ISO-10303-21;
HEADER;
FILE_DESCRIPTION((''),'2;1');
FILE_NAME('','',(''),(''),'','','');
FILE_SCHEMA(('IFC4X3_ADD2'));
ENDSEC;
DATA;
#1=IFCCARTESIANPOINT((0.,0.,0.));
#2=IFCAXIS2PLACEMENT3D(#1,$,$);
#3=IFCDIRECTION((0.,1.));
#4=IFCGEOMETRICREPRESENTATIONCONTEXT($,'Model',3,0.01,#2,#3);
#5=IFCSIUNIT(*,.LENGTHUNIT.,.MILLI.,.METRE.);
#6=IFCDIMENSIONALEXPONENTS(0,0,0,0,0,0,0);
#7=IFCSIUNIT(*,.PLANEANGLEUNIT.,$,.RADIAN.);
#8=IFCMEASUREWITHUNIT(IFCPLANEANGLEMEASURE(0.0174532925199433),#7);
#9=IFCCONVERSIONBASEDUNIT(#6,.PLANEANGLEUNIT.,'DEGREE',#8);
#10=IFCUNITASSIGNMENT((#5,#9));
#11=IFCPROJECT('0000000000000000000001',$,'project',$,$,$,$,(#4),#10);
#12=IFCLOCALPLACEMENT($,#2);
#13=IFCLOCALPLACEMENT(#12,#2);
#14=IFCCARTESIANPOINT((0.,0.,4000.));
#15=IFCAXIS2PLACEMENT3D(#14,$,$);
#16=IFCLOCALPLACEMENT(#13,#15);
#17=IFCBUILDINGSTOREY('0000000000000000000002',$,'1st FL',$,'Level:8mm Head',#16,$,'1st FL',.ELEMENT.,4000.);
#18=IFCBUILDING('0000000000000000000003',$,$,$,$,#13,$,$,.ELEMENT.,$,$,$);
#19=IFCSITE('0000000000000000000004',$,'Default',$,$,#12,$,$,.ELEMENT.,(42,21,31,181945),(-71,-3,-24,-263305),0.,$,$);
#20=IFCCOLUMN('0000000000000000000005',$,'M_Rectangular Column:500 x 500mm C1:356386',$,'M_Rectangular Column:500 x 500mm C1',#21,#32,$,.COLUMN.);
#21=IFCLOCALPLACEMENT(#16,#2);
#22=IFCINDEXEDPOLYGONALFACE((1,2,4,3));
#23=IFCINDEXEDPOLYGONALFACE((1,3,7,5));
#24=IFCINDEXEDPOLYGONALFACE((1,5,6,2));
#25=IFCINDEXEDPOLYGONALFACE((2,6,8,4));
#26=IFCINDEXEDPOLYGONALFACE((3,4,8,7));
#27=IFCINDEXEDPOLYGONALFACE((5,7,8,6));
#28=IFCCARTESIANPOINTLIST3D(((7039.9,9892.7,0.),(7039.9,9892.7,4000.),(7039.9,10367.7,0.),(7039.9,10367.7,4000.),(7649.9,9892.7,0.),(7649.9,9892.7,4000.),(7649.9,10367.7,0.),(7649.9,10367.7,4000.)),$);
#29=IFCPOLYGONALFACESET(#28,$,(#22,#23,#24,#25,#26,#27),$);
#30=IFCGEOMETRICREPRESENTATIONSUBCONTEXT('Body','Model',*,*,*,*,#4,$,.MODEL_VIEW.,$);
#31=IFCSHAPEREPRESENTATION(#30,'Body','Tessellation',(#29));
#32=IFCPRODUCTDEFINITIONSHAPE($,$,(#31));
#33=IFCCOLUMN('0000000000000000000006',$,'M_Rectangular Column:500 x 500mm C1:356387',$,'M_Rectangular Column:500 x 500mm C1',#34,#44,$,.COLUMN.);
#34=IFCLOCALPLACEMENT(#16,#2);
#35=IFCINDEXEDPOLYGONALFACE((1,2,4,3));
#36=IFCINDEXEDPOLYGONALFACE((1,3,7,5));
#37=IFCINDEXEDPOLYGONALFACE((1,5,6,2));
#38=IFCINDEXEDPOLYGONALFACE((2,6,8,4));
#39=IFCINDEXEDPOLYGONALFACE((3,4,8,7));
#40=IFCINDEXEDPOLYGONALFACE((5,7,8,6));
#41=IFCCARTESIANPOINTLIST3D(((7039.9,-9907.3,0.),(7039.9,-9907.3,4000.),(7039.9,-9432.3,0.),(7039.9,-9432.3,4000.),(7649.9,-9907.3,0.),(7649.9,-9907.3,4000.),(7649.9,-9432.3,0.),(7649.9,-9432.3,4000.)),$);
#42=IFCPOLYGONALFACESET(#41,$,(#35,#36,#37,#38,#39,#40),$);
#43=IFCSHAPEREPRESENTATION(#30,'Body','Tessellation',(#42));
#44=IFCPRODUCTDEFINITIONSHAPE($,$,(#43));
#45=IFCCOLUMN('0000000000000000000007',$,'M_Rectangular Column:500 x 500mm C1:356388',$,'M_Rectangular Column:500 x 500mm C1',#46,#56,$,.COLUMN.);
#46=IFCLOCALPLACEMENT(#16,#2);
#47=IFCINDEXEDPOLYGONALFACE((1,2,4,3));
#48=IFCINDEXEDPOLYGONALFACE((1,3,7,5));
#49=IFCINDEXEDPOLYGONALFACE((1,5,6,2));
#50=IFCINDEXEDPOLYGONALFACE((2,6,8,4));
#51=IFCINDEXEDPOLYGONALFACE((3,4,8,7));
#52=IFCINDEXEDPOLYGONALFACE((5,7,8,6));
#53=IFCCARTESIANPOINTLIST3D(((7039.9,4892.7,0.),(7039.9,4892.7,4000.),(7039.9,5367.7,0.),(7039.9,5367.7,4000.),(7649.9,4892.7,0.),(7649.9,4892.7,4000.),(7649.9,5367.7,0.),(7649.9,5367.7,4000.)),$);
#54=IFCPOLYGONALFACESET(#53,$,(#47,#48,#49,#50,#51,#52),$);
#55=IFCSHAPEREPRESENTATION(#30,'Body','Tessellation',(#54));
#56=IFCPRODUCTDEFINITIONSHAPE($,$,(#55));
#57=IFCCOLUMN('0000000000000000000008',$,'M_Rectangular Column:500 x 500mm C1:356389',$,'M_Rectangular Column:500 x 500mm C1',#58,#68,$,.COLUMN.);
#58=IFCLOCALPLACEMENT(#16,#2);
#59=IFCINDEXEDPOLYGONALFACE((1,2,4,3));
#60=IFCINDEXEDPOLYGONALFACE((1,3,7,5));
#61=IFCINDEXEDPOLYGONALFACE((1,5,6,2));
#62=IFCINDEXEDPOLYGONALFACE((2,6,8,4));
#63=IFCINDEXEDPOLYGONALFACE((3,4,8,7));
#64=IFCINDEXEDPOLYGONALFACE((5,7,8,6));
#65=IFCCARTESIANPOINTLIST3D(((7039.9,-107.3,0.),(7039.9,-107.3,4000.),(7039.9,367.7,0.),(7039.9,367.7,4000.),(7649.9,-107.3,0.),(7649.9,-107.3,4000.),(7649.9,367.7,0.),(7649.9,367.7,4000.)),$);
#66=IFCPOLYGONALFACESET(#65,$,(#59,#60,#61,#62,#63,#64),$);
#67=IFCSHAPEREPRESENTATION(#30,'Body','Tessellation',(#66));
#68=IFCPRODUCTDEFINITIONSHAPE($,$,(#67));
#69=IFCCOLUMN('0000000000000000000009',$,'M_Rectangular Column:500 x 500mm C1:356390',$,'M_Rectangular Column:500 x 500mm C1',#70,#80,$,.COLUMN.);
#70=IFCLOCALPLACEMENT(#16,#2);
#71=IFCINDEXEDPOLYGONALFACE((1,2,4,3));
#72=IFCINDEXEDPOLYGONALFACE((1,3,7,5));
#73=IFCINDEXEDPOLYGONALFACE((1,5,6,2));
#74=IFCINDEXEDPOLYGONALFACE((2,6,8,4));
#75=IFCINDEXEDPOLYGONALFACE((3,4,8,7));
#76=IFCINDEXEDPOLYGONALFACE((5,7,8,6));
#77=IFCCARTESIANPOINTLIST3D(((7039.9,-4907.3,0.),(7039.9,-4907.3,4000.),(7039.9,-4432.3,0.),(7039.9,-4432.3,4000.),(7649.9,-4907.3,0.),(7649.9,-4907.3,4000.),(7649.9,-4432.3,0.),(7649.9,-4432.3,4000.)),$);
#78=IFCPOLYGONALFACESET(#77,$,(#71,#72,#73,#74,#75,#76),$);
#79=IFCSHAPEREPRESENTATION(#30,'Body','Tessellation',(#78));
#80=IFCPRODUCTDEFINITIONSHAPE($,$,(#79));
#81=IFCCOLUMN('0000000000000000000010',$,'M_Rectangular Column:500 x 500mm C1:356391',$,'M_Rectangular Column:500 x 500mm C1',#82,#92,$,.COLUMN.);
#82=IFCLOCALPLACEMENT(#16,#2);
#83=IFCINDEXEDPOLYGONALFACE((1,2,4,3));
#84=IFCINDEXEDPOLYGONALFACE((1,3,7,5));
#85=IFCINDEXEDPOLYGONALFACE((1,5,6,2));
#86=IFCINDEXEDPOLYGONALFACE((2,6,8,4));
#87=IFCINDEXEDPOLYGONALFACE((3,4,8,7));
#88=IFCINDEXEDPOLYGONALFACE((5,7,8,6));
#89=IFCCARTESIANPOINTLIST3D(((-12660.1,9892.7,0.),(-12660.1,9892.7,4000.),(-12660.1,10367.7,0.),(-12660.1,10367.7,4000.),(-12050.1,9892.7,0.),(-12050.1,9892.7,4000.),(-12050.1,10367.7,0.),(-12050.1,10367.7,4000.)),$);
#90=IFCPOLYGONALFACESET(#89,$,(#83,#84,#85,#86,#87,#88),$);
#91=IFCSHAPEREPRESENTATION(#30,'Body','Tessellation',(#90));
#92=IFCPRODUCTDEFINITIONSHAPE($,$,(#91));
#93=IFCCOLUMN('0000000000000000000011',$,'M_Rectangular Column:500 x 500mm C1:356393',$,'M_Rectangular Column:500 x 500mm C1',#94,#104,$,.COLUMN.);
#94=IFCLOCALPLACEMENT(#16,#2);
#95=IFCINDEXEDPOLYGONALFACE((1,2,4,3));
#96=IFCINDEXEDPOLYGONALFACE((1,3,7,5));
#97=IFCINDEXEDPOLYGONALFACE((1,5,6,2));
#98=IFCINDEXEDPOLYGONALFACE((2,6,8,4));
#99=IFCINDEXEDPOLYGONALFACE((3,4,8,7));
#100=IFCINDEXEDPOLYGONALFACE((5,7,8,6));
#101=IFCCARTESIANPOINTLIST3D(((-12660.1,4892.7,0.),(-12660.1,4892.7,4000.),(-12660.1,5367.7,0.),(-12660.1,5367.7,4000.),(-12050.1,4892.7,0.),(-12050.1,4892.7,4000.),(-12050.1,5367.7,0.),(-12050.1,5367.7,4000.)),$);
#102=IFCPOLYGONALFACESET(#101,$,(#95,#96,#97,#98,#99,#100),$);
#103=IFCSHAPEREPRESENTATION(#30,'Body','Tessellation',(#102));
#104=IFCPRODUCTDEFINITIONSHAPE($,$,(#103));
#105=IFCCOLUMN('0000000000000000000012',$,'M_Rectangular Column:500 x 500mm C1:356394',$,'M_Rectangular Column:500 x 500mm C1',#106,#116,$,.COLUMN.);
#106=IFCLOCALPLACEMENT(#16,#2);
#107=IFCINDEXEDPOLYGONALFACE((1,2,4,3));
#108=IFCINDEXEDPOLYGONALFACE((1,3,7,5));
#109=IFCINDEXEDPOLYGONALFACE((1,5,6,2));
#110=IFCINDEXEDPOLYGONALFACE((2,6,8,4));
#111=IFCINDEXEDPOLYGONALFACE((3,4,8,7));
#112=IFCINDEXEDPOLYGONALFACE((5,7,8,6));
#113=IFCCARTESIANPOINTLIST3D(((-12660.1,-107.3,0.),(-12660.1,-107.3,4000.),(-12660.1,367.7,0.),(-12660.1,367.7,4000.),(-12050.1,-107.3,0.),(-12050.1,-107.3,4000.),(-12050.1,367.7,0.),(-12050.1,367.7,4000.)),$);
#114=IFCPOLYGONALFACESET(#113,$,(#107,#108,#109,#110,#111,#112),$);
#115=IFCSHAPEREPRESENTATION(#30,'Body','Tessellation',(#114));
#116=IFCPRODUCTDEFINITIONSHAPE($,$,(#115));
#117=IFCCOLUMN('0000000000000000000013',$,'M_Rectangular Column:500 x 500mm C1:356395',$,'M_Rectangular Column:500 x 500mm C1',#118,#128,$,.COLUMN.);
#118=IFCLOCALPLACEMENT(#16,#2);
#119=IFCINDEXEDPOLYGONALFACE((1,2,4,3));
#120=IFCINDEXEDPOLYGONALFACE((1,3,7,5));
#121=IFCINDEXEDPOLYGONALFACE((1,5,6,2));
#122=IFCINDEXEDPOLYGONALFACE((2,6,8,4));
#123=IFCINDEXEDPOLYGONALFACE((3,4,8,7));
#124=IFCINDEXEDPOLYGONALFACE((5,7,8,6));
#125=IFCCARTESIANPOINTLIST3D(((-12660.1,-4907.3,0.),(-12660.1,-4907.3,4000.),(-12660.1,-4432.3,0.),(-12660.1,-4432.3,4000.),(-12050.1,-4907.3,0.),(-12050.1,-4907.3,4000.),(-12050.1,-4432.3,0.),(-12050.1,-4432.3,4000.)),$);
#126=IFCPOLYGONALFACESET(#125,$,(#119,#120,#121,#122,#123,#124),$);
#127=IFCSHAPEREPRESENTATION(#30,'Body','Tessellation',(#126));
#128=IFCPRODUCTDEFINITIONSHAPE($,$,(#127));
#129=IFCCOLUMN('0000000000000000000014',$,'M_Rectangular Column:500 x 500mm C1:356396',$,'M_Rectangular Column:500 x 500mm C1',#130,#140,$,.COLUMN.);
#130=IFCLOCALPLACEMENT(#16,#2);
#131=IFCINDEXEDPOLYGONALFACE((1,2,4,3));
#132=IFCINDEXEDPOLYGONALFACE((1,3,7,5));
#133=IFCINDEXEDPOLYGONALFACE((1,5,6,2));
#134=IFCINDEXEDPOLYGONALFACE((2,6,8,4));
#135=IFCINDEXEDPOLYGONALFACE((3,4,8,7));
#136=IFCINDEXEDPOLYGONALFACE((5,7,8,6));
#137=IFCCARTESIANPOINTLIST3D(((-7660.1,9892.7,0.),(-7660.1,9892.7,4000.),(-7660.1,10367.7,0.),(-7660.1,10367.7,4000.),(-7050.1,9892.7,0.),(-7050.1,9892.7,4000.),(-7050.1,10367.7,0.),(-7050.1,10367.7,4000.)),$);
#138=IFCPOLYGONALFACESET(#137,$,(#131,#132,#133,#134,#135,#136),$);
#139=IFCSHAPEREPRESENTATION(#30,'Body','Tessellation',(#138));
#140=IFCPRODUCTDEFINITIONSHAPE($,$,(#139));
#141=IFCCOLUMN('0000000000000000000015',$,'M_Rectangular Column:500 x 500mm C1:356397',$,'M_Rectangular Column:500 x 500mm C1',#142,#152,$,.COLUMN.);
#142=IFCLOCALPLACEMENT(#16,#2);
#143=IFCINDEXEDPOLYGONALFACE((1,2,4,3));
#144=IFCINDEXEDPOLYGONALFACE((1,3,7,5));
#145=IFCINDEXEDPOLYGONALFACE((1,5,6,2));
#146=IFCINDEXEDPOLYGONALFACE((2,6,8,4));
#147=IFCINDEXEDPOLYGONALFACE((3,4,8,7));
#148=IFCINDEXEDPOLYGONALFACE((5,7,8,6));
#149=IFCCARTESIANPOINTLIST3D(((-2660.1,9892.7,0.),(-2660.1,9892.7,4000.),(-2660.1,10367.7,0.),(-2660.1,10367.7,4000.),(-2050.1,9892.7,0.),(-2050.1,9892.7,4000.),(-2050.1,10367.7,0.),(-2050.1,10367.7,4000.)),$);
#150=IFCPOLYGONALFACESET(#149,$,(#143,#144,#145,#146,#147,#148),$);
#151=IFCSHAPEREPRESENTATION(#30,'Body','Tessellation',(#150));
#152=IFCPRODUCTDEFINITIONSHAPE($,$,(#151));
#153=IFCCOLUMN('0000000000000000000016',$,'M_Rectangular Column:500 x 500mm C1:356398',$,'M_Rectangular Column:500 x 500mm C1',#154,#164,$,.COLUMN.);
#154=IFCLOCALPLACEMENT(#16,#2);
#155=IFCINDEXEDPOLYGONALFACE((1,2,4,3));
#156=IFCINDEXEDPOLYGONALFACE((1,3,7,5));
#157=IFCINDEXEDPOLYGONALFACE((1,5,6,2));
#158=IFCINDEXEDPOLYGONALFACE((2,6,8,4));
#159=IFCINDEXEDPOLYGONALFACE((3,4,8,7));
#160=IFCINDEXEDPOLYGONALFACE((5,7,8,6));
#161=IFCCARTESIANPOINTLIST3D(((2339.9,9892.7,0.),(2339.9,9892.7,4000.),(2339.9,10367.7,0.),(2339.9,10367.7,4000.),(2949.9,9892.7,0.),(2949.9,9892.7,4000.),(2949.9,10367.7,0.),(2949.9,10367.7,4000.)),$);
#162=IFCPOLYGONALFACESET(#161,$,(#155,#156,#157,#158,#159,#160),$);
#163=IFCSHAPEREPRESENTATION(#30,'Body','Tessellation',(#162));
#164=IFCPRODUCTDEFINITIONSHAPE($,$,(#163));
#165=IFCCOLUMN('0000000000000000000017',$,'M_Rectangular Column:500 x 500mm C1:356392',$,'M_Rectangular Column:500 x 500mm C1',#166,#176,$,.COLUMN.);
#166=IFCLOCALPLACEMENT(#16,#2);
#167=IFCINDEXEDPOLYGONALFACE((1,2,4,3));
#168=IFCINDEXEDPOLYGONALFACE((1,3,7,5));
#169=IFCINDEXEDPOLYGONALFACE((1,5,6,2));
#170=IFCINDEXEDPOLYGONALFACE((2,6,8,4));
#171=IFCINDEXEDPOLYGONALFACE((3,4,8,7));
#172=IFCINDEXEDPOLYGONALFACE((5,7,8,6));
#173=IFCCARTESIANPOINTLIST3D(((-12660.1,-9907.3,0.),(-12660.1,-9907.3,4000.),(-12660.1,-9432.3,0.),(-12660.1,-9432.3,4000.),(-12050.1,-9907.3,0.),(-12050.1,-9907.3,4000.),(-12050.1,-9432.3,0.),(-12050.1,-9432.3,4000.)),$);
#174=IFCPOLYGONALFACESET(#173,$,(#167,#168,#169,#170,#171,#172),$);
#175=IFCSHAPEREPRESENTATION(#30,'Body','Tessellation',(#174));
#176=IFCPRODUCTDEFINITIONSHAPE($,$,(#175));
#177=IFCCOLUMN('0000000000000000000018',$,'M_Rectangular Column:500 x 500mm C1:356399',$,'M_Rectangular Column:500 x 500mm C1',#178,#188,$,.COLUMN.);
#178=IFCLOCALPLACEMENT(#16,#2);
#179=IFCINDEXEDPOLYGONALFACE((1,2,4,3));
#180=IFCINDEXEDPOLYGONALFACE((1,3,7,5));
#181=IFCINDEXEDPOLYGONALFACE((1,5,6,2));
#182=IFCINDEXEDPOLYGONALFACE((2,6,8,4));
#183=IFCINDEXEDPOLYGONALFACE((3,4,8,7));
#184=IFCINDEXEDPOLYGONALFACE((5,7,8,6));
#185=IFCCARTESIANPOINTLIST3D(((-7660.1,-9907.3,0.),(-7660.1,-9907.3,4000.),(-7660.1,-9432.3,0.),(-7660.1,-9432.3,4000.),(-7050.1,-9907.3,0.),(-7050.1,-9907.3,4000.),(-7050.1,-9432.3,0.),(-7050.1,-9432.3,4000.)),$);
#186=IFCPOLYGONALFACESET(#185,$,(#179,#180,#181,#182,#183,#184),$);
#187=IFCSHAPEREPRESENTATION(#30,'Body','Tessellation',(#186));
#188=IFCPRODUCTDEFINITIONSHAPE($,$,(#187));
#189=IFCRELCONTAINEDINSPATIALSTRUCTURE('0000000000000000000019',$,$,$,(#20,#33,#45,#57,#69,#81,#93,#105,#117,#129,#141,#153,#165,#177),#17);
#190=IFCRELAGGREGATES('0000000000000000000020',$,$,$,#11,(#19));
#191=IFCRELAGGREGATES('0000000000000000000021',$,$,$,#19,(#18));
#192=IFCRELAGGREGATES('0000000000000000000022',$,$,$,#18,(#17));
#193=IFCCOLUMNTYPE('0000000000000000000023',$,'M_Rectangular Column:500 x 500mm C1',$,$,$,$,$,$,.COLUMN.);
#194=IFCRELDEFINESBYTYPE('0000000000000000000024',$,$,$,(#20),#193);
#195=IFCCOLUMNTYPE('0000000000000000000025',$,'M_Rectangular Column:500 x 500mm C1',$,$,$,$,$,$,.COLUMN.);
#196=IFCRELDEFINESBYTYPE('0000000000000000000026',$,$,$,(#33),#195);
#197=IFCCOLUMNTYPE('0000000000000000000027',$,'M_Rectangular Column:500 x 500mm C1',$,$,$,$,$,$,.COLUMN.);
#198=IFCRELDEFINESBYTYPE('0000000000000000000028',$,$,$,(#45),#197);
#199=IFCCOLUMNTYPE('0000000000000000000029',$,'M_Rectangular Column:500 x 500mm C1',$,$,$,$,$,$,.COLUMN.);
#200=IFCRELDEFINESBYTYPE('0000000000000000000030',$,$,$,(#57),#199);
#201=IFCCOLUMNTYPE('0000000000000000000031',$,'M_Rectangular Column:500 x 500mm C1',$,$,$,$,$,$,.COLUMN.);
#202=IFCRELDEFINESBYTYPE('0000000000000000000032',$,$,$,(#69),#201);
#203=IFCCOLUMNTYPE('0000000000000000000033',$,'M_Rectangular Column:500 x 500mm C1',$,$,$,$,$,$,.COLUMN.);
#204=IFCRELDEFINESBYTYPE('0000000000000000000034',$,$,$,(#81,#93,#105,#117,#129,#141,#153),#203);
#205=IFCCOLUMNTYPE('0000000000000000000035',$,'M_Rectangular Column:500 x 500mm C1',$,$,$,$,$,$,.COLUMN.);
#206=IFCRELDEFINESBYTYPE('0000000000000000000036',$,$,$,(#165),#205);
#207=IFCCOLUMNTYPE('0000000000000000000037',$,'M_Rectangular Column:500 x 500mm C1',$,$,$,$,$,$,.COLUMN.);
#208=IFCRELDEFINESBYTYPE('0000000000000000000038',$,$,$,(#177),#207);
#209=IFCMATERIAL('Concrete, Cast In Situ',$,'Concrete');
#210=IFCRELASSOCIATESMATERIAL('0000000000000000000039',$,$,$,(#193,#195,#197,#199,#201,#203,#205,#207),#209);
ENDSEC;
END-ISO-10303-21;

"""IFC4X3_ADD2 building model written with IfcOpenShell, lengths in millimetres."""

from ifc_helpers import new_model, entity, si_unit, converted_unit, direction, frame, frame_2d, origin, origin_2d_with_axis, place, context, subcontext, project, spatial, rectangle, extrude, source, transform, mapped, material, material_profile, profile_set, type_object, type_shapes, element, save


model = new_model("IFC4X3_ADD2")

# Units and contexts
model_context = context("Model", 3, precision=0.01, world=origin(), true_north=direction((0.0, 1.0)))
body_context = subcontext(model_context, "Body", "Model", "MODEL_VIEW")
ifc_project = project(units=[si_unit("LENGTHUNIT", "METRE", prefix="MILLI"), converted_unit("PLANEANGLEUNIT", "DEGREE", entity("IfcPlaneAngleMeasure", 0.0174532925199433), si_unit("PLANEANGLEUNIT", "RADIAN"), dimensions=[0, 0, 0, 0, 0, 0, 0])], contexts=[model_context])

# Site, building, storey
site_placement = place(None, origin())
site = spatial("IfcSite", under=ifc_project, at=site_placement, Name="Default", CompositionType="ELEMENT", RefLatitude=(42, 21, 31, 181945), RefLongitude=(-71, -3, -24, -263305), RefElevation=0.0)
building_placement = place(site_placement, origin())
building = spatial("IfcBuilding", under=site, at=building_placement, CompositionType="ELEMENT")
storey_placement = place(building_placement, frame((0.0, 0.0, 4000.0)))
storey = spatial("IfcBuildingStorey", under=building, at=storey_placement, Name="1st FL", ObjectType="Level:8mm Head", LongName="1st FL", CompositionType="ELEMENT", Elevation=4000.0)

# Columns
ifc_material_1 = material(Name="Concrete, Cast In Situ", Category="Concrete")
ifc_material_profile_1 = material_profile(ifc_material_1, rectangle(XDim=610.0, YDim=475.0, at=frame_2d((0.0, 0.0), x_axis=(1.0, 0.0))), Name="500 x 500mm C1")
ifc_profile_set_1 = profile_set([ifc_material_profile_1], Name="500 x 500mm C1")
column_type_1 = type_object("IfcColumnType", Name="M_Rectangular Column:500 x 500mm C1", PredefinedType="COLUMN", material=ifc_profile_set_1)
shared_shape_1 = source(origin(), body_context, "Body", "SweptSolid", [
    extrude(rectangle(XDim=610.0, YDim=475.0, at=frame_2d((0.0, 0.0), x_axis=(1.0, 0.0))), frame((7344.9, 10130.2, 4000.0), z_axis=(0.0, 0.0, 1.0), x_axis=(-1.0, 0.0, 0.0)), (0.0, 0.0, 1.0), 4000.0),
])
type_shapes(column_type_1, [shared_shape_1])
column_1_placement = place(storey_placement, frame((0.0, 0.0, -4000.0)))
element("IfcColumn", 1, at=column_1_placement, inside=storey, type_object=column_type_1, Name="M_Rectangular Column:500 x 500mm C1:356386", ObjectType="M_Rectangular Column:500 x 500mm C1", PredefinedType="COLUMN", context=body_context, shape_type="MappedRepresentation", body=[
    mapped(shared_shape_1, transform((0.0, 0.0, 0.0), scale=1.0)),
])
column_type_2 = type_object("IfcColumnType", Name="M_Rectangular Column:500 x 500mm C1", PredefinedType="COLUMN", material=ifc_profile_set_1)
shared_shape_2 = source(origin(), body_context, "Body", "SweptSolid", [
    extrude(rectangle(XDim=610.0, YDim=475.0, at=origin_2d_with_axis()), frame((7344.9, -9669.8, 4000.0), z_axis=(0.0, 0.0, 1.0), x_axis=(-1.0, 0.0, 0.0)), (0.0, 0.0, 1.0), 4000.0),
])
type_shapes(column_type_2, [shared_shape_2])
column_2_placement = place(storey_placement, frame((0.0, 0.0, -4000.0)))
element("IfcColumn", 2, at=column_2_placement, inside=storey, type_object=column_type_2, Name="M_Rectangular Column:500 x 500mm C1:356387", ObjectType="M_Rectangular Column:500 x 500mm C1", PredefinedType="COLUMN", context=body_context, shape_type="MappedRepresentation", body=[
    mapped(shared_shape_2, transform((0.0, 0.0, 0.0), scale=1.0)),
])
column_type_3 = type_object("IfcColumnType", Name="M_Rectangular Column:500 x 500mm C1", PredefinedType="COLUMN", material=ifc_profile_set_1)
shared_shape_3 = source(origin(), body_context, "Body", "SweptSolid", [
    extrude(rectangle(XDim=610.0, YDim=475.0, at=frame_2d((0.0, 0.0), x_axis=(1.0, 0.0))), frame((7344.9, 5130.2, 4000.0), z_axis=(0.0, 0.0, 1.0), x_axis=(-1.0, 0.0, 0.0)), (0.0, 0.0, 1.0), 4000.0),
])
type_shapes(column_type_3, [shared_shape_3])
column_3_placement = place(storey_placement, frame((0.0, 0.0, -4000.0)))
element("IfcColumn", 3, at=column_3_placement, inside=storey, type_object=column_type_3, Name="M_Rectangular Column:500 x 500mm C1:356388", ObjectType="M_Rectangular Column:500 x 500mm C1", PredefinedType="COLUMN", context=body_context, shape_type="MappedRepresentation", body=[
    mapped(shared_shape_3, transform((0.0, 0.0, 0.0), scale=1.0)),
])
column_type_4 = type_object("IfcColumnType", Name="M_Rectangular Column:500 x 500mm C1", PredefinedType="COLUMN", material=ifc_profile_set_1)
shared_shape_4 = source(origin(), body_context, "Body", "SweptSolid", [
    extrude(rectangle(XDim=610.0, YDim=475.0, at=origin_2d_with_axis()), frame((7344.9, 130.2, 4000.0), z_axis=(0.0, 0.0, 1.0), x_axis=(-1.0, 0.0, 0.0)), (0.0, 0.0, 1.0), 4000.0),
])
type_shapes(column_type_4, [shared_shape_4])
column_4_placement = place(storey_placement, frame((0.0, 0.0, -4000.0)))
element("IfcColumn", 4, at=column_4_placement, inside=storey, type_object=column_type_4, Name="M_Rectangular Column:500 x 500mm C1:356389", ObjectType="M_Rectangular Column:500 x 500mm C1", PredefinedType="COLUMN", context=body_context, shape_type="MappedRepresentation", body=[
    mapped(shared_shape_4, transform((0.0, 0.0, 0.0), scale=1.0)),
])
column_type_5 = type_object("IfcColumnType", Name="M_Rectangular Column:500 x 500mm C1", PredefinedType="COLUMN", material=ifc_profile_set_1)
shared_shape_5 = source(origin(), body_context, "Body", "SweptSolid", [
    extrude(rectangle(XDim=610.0, YDim=475.0, at=origin_2d_with_axis()), frame((7344.9, -4669.8, 4000.0), z_axis=(0.0, 0.0, 1.0), x_axis=(-1.0, 0.0, 0.0)), (0.0, 0.0, 1.0), 4000.0),
])
type_shapes(column_type_5, [shared_shape_5])
column_5_placement = place(storey_placement, frame((0.0, 0.0, -4000.0)))
element("IfcColumn", 5, at=column_5_placement, inside=storey, type_object=column_type_5, Name="M_Rectangular Column:500 x 500mm C1:356390", ObjectType="M_Rectangular Column:500 x 500mm C1", PredefinedType="COLUMN", context=body_context, shape_type="MappedRepresentation", body=[
    mapped(shared_shape_5, transform((0.0, 0.0, 0.0), scale=1.0)),
])
column_type_6 = type_object("IfcColumnType", Name="M_Rectangular Column:500 x 500mm C1", PredefinedType="COLUMN", material=ifc_profile_set_1)
shared_shape_6 = source(origin(), body_context, "Body", "SweptSolid", [
    extrude(rectangle(XDim=610.0, YDim=475.0, at=origin_2d_with_axis()), frame((0.0, 0.0, 4000.0), z_axis=(0.0, 0.0, 1.0), x_axis=(-1.0, 0.0, 0.0)), (0.0, 0.0, 1.0), 4000.0),
])
type_shapes(column_type_6, [shared_shape_6])
for number, where, name in (
    (6, (-12355.1, 10130.2, -4000.0), "M_Rectangular Column:500 x 500mm C1:356391"),
    (7, (-12355.1, 5130.2, -4000.0), "M_Rectangular Column:500 x 500mm C1:356393"),
    (8, (-12355.1, 130.2, -4000.0), "M_Rectangular Column:500 x 500mm C1:356394"),
    (9, (-12355.1, -4669.8, -4000.0), "M_Rectangular Column:500 x 500mm C1:356395"),
    (10, (-7355.1, 10130.2, -4000.0), "M_Rectangular Column:500 x 500mm C1:356396"),
    (11, (-2355.1, 10130.2, -4000.0), "M_Rectangular Column:500 x 500mm C1:356397"),
    (12, (2644.9, 10130.2, -4000.0), "M_Rectangular Column:500 x 500mm C1:356398"),
):
    element("IfcColumn", number, at=place(storey_placement, frame(where)), inside=storey, type_object=column_type_6, Name=name, ObjectType="M_Rectangular Column:500 x 500mm C1", PredefinedType="COLUMN", context=body_context, shape_type="MappedRepresentation", body=[
        mapped(shared_shape_6, transform((0.0, 0.0, 0.0), scale=1.0)),
    ])
column_type_7 = type_object("IfcColumnType", Name="M_Rectangular Column:500 x 500mm C1", PredefinedType="COLUMN", material=ifc_profile_set_1)
shared_shape_7 = source(origin(), body_context, "Body", "SweptSolid", [
    extrude(rectangle(XDim=610.0, YDim=475.0, at=frame_2d((0.0, 0.0), x_axis=(1.0, 0.0))), frame((-12355.1, -9669.8, 4000.0), z_axis=(0.0, 0.0, 1.0), x_axis=(-1.0, 0.0, 0.0)), (0.0, 0.0, 1.0), 4000.0),
])
type_shapes(column_type_7, [shared_shape_7])
column_6_placement = place(storey_placement, frame((0.0, 0.0, -4000.0)))
element("IfcColumn", 13, at=column_6_placement, inside=storey, type_object=column_type_7, Name="M_Rectangular Column:500 x 500mm C1:356392", ObjectType="M_Rectangular Column:500 x 500mm C1", PredefinedType="COLUMN", context=body_context, shape_type="MappedRepresentation", body=[
    mapped(shared_shape_7, transform((0.0, 0.0, 0.0), scale=1.0)),
])
column_type_8 = type_object("IfcColumnType", Name="M_Rectangular Column:500 x 500mm C1", PredefinedType="COLUMN", material=ifc_profile_set_1)
shared_shape_8 = source(origin(), body_context, "Body", "SweptSolid", [
    extrude(rectangle(XDim=610.0, YDim=475.0, at=origin_2d_with_axis()), frame((-7355.1, -9669.8, 4000.0), z_axis=(0.0, 0.0, 1.0), x_axis=(-1.0, 0.0, 0.0)), (0.0, 0.0, 1.0), 4000.0),
])
type_shapes(column_type_8, [shared_shape_8])
column_7_placement = place(storey_placement, frame((0.0, 0.0, -4000.0)))
element("IfcColumn", 14, at=column_7_placement, inside=storey, type_object=column_type_8, Name="M_Rectangular Column:500 x 500mm C1:356399", ObjectType="M_Rectangular Column:500 x 500mm C1", PredefinedType="COLUMN", context=body_context, shape_type="MappedRepresentation", body=[
    mapped(shared_shape_8, transform((0.0, 0.0, 0.0), scale=1.0)),
])

save(model, "model.ifc")
